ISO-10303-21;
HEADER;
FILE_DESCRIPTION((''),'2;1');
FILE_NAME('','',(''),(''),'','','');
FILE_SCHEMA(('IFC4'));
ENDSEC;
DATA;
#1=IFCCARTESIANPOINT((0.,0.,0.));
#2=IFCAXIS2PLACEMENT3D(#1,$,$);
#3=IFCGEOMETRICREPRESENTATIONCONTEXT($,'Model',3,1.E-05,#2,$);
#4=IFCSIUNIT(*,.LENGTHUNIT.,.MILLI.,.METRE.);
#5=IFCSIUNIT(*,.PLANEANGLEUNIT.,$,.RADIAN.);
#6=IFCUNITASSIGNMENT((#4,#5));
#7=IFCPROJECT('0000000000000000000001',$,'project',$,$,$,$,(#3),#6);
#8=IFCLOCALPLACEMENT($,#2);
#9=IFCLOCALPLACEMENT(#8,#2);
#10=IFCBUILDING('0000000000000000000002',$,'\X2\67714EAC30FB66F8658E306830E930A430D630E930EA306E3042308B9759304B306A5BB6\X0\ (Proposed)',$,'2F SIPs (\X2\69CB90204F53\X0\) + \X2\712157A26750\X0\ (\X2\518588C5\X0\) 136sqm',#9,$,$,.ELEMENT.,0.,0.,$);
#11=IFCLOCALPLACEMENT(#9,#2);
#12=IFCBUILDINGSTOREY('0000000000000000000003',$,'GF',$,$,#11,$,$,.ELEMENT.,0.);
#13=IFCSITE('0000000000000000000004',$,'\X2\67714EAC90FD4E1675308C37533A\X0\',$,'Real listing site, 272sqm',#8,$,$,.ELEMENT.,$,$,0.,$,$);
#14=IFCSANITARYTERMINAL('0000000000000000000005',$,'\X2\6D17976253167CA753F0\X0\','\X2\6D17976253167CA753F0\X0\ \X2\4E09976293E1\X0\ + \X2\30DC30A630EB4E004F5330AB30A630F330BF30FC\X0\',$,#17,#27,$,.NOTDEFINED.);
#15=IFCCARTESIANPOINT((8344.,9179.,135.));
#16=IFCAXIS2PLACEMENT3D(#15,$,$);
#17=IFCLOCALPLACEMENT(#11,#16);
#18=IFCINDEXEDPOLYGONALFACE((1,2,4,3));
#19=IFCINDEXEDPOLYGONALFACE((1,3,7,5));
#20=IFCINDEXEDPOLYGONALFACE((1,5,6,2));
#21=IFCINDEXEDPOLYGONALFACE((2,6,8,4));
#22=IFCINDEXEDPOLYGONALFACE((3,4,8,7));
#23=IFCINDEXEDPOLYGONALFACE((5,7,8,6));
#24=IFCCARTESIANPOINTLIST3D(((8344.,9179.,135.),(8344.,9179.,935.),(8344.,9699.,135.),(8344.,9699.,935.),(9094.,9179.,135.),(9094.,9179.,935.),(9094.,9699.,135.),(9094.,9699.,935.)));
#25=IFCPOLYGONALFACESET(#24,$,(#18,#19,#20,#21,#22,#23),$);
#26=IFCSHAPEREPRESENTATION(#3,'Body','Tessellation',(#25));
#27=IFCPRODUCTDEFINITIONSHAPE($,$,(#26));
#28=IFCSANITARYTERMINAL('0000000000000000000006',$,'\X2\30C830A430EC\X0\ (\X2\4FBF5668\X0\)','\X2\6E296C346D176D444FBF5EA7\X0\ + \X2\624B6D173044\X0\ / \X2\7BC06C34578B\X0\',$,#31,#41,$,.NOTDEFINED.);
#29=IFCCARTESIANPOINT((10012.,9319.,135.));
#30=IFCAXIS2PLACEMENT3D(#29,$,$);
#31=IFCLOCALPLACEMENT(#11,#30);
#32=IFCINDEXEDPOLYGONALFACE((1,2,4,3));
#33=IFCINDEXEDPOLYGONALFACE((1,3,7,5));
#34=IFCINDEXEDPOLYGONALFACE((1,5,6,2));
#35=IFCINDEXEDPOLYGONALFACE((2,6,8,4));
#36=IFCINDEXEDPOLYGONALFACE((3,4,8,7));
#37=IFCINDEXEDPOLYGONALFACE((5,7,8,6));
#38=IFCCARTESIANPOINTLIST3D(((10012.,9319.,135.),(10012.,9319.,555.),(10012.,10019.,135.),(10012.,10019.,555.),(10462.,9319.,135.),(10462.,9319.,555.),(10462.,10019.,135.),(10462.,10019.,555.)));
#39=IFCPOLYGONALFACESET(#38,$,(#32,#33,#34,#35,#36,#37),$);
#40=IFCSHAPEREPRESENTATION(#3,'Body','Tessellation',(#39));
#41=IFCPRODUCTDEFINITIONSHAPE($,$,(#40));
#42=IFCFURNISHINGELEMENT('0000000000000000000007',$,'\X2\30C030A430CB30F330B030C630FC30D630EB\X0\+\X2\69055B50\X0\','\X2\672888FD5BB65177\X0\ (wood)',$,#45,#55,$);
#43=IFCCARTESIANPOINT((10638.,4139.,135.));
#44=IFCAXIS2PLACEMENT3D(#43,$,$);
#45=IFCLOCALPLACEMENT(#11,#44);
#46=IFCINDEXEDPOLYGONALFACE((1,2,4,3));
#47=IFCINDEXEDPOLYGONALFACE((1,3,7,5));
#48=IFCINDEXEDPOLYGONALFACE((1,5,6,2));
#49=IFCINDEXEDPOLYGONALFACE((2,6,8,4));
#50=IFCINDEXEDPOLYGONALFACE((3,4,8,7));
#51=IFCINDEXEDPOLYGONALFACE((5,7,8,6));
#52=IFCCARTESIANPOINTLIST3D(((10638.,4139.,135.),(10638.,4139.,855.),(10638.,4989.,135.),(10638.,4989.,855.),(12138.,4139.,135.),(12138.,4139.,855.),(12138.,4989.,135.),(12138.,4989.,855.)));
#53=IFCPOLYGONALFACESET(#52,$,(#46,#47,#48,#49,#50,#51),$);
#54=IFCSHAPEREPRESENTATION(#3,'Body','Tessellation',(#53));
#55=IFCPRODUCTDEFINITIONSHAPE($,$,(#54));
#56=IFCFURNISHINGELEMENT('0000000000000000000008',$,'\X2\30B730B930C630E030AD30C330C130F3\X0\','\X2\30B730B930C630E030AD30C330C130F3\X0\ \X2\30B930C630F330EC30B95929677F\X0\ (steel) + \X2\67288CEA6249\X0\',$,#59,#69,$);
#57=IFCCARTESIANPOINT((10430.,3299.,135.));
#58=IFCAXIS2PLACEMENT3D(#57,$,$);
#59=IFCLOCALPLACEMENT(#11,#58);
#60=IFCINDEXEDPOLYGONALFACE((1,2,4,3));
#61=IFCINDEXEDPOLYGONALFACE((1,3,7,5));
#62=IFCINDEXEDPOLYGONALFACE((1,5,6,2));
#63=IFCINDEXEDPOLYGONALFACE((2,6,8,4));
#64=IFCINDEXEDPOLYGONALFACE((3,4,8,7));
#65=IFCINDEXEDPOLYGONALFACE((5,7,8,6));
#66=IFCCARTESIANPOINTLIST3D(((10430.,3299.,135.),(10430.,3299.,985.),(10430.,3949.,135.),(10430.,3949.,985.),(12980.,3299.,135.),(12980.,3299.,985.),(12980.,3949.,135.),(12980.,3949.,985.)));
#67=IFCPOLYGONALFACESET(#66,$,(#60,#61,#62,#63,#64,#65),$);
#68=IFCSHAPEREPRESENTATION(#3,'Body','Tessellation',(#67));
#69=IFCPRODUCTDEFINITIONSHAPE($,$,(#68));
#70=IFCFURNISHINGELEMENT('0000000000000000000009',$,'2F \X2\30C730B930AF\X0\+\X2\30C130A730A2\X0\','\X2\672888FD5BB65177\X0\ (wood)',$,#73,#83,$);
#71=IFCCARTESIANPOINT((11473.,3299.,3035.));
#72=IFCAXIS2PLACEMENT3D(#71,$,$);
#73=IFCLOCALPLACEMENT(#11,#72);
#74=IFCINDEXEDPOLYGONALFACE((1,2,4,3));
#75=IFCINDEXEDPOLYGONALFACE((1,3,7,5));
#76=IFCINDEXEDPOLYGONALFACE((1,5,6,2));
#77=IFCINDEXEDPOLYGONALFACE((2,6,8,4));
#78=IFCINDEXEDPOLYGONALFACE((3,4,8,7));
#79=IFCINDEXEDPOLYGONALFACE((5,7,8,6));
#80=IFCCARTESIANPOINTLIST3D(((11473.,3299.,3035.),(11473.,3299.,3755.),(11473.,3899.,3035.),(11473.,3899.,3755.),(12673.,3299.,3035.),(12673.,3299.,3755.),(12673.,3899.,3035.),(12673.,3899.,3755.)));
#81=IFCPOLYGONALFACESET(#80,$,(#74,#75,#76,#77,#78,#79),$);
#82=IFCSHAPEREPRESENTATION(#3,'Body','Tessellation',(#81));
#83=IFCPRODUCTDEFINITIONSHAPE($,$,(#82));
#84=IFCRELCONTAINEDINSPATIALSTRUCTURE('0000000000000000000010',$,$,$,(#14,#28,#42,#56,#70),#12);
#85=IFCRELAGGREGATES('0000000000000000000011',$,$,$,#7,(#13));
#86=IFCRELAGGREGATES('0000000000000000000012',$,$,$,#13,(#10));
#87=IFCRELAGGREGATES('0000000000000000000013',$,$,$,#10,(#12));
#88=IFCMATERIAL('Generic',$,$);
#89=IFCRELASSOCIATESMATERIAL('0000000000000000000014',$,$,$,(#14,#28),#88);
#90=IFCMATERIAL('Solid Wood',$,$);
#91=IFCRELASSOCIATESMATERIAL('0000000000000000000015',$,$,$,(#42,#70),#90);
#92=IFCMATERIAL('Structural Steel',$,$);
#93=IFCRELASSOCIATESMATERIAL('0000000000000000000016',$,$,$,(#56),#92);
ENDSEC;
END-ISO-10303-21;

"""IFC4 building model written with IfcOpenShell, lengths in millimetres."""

from ifc_helpers import new_model, si_unit, frame, frame_2d, origin, place, context, project, spatial, rectangle, extrude, material, element, save


model = new_model("IFC4")

# Units and contexts
model_context = context("Model", 3, precision=1e-05, world=origin())
ifc_project = project(units=[si_unit("LENGTHUNIT", "METRE", prefix="MILLI"), si_unit("PLANEANGLEUNIT", "RADIAN")], contexts=[model_context])

# Site, building, storey
site_placement = place(None, origin())
site = spatial("IfcSite", under=ifc_project, at=site_placement, Name="東京都世田谷区", ObjectType="Real listing site, 272sqm", CompositionType="ELEMENT", RefElevation=0.0)
building_placement = place(site_placement, origin())
building = spatial("IfcBuilding", under=site, at=building_placement, Name="東京・書斎とライブラリのある静かな家 (Proposed)", ObjectType="2F SIPs (構造体) + 無垢材 (内装) 136sqm", CompositionType="ELEMENT", ElevationOfRefHeight=0.0, ElevationOfTerrain=0.0)
storey_placement = place(building_placement, origin())
storey = spatial("IfcBuildingStorey", under=building, at=storey_placement, Name="GF", CompositionType="ELEMENT", Elevation=0.0)

# Shared definitions
ifc_material_1 = material(Name="Solid Wood")

# Sanitary terminals
ifc_material_2 = material(Name="Generic")
sanitary_terminal_1_placement = place(storey_placement, frame((8344.0, 9179.0, 135.0)))
element("IfcSanitaryTerminal", 1, at=sanitary_terminal_1_placement, inside=storey, material=ifc_material_2, Name="洗面化粧台", Description="洗面化粧台 三面鏡 + ボウル一体カウンター", PredefinedType="NOTDEFINED", context=model_context, shape_type="SweptSolid", body=[
    extrude(rectangle(XDim=750.0, YDim=520.0, at=frame_2d((375.0, 260.0))), frame((8344.0, 9179.0, 135.0)), (0.0, 0.0, 1.0), 800.0),
])
sanitary_terminal_2_placement = place(storey_placement, frame((10012.0, 9319.0, 135.0)))
element("IfcSanitaryTerminal", 2, at=sanitary_terminal_2_placement, inside=storey, material=ifc_material_2, Name="トイレ (便器)", Description="温水洗浄便座 + 手洗い / 節水型", PredefinedType="NOTDEFINED", context=model_context, shape_type="SweptSolid", body=[
    extrude(rectangle(XDim=450.0, YDim=700.0, at=frame_2d((225.0, 350.0))), frame((10012.0, 9319.0, 135.0)), (0.0, 0.0, 1.0), 420.0),
])

# Furnishing elements
furnishing_1_placement = place(storey_placement, frame((10638.0, 4139.0, 135.0)))
element("IfcFurnishingElement", 3, at=furnishing_1_placement, inside=storey, material=ifc_material_1, Name="ダイニングテーブル+椅子", Description="木製家具 (wood)", context=model_context, shape_type="SweptSolid", body=[
    extrude(rectangle(XDim=1500.0, YDim=850.0, at=frame_2d((750.0, 425.0))), frame((10638.0, 4139.0, 135.0)), (0.0, 0.0, 1.0), 720.0),
])
ifc_material_3 = material(Name="Structural Steel")
furnishing_2_placement = place(storey_placement, frame((10430.0, 3299.0, 135.0)))
element("IfcFurnishingElement", 4, at=furnishing_2_placement, inside=storey, material=ifc_material_3, Name="システムキッチン", Description="システムキッチン ステンレス天板 (steel) + 木質扉", context=model_context, shape_type="SweptSolid", body=[
    extrude(rectangle(XDim=2550.0, YDim=650.0, at=frame_2d((1275.0, 325.0))), frame((10430.0, 3299.0, 135.0)), (0.0, 0.0, 1.0), 850.0),
])
furnishing_3_placement = place(storey_placement, frame((11473.0, 3299.0, 3035.0)))
element("IfcFurnishingElement", 5, at=furnishing_3_placement, inside=storey, material=ifc_material_1, Name="2F デスク+チェア", Description="木製家具 (wood)", context=model_context, shape_type="SweptSolid", body=[
    extrude(rectangle(XDim=1200.0, YDim=600.0, at=frame_2d((600.0, 300.0))), frame((11473.0, 3299.0, 3035.0)), (0.0, 0.0, 1.0), 720.0),
])

save(model, "model.ifc")
